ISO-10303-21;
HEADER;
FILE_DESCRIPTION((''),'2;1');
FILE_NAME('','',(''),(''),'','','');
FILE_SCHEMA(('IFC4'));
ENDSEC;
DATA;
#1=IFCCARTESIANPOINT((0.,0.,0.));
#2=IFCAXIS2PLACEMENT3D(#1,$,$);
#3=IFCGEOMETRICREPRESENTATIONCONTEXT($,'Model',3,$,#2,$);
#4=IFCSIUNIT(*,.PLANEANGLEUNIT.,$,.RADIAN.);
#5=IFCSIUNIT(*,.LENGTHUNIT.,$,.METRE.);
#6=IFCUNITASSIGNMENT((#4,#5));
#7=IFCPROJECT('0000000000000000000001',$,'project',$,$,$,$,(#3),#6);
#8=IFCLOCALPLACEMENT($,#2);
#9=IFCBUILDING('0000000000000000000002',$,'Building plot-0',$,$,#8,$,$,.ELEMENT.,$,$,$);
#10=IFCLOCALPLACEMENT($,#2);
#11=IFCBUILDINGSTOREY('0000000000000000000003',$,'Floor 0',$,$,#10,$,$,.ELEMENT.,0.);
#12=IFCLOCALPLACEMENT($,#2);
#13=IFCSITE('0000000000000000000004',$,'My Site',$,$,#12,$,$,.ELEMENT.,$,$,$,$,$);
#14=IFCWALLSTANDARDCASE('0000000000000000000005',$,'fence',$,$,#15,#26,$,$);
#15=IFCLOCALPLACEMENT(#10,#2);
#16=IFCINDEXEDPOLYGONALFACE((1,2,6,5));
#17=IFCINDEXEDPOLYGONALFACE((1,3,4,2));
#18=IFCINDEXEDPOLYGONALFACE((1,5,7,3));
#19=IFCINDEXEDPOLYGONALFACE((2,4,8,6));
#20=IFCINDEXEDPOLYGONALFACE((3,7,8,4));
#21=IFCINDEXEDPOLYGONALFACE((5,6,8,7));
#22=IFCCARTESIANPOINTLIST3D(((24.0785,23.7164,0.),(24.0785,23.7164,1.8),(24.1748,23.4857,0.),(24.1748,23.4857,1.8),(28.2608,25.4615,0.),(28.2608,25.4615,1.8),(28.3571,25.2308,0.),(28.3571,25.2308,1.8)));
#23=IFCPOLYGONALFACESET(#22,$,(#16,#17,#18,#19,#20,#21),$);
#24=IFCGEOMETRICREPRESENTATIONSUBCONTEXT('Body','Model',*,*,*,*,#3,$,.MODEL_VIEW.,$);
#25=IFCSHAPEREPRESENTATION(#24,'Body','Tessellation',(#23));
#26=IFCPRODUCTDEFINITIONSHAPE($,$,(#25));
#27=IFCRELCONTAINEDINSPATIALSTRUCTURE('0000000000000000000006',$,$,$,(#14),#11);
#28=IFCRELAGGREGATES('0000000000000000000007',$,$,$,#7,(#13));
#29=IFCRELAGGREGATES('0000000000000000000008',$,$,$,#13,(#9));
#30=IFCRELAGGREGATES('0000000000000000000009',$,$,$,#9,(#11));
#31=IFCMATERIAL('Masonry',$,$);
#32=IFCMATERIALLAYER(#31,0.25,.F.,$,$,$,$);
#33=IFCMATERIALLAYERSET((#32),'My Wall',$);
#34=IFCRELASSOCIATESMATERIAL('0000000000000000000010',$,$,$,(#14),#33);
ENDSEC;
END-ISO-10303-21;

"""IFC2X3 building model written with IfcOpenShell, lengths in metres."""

from ifc_helpers import new_model, si_unit, origin, place, context, subcontext, project, spatial, polyline, outline, extrude, material, layer, layer_set, layer_usage, element, save


model = new_model("IFC2X3")

# Units and contexts
model_context = context("Model", 3, world=origin())
body_context = subcontext(model_context, "Body", "Model", "MODEL_VIEW")
ifc_project = project(units=[si_unit("PLANEANGLEUNIT", "RADIAN"), si_unit("LENGTHUNIT", "METRE")], contexts=[model_context])

# Site, building, storey
site_placement = place(None, origin())
site = spatial("IfcSite", under=ifc_project, at=site_placement, Name="My Site", CompositionType="ELEMENT")
building_placement = place(None, origin())
building = spatial("IfcBuilding", under=site, at=building_placement, Name="Building plot-0", CompositionType="ELEMENT")
storey_placement = place(None, origin())
storey = spatial("IfcBuildingStorey", under=building, at=storey_placement, Name="Floor 0", CompositionType="ELEMENT", Elevation=0.0)

# Wall
ifc_material_1 = material(Name="Masonry")
ifc_layer_1 = layer(ifc_material_1, 0.25, ventilated=False)
ifc_layer_set_1 = layer_set([ifc_layer_1], Name="My Wall")
ifc_layer_usage_1 = layer_usage(ifc_layer_set_1, "AXIS2", "NEGATIVE", 0.0)
wall_1_placement = place(storey_placement, origin())
element("IfcWallStandardCase", 1, at=wall_1_placement, inside=storey, material=ifc_layer_usage_1, Name="fence", context=body_context, shape_type="SweptSolid", body=[
    extrude(outline(polyline([(24.0785, 23.7164), (24.1748, 23.4857), (28.3571, 25.2308), (28.2608, 25.4615), (24.0785, 23.7164)])), origin(), (0.0, 0.0, 1.0), 1.8),
])

save(model, "model.ifc")
